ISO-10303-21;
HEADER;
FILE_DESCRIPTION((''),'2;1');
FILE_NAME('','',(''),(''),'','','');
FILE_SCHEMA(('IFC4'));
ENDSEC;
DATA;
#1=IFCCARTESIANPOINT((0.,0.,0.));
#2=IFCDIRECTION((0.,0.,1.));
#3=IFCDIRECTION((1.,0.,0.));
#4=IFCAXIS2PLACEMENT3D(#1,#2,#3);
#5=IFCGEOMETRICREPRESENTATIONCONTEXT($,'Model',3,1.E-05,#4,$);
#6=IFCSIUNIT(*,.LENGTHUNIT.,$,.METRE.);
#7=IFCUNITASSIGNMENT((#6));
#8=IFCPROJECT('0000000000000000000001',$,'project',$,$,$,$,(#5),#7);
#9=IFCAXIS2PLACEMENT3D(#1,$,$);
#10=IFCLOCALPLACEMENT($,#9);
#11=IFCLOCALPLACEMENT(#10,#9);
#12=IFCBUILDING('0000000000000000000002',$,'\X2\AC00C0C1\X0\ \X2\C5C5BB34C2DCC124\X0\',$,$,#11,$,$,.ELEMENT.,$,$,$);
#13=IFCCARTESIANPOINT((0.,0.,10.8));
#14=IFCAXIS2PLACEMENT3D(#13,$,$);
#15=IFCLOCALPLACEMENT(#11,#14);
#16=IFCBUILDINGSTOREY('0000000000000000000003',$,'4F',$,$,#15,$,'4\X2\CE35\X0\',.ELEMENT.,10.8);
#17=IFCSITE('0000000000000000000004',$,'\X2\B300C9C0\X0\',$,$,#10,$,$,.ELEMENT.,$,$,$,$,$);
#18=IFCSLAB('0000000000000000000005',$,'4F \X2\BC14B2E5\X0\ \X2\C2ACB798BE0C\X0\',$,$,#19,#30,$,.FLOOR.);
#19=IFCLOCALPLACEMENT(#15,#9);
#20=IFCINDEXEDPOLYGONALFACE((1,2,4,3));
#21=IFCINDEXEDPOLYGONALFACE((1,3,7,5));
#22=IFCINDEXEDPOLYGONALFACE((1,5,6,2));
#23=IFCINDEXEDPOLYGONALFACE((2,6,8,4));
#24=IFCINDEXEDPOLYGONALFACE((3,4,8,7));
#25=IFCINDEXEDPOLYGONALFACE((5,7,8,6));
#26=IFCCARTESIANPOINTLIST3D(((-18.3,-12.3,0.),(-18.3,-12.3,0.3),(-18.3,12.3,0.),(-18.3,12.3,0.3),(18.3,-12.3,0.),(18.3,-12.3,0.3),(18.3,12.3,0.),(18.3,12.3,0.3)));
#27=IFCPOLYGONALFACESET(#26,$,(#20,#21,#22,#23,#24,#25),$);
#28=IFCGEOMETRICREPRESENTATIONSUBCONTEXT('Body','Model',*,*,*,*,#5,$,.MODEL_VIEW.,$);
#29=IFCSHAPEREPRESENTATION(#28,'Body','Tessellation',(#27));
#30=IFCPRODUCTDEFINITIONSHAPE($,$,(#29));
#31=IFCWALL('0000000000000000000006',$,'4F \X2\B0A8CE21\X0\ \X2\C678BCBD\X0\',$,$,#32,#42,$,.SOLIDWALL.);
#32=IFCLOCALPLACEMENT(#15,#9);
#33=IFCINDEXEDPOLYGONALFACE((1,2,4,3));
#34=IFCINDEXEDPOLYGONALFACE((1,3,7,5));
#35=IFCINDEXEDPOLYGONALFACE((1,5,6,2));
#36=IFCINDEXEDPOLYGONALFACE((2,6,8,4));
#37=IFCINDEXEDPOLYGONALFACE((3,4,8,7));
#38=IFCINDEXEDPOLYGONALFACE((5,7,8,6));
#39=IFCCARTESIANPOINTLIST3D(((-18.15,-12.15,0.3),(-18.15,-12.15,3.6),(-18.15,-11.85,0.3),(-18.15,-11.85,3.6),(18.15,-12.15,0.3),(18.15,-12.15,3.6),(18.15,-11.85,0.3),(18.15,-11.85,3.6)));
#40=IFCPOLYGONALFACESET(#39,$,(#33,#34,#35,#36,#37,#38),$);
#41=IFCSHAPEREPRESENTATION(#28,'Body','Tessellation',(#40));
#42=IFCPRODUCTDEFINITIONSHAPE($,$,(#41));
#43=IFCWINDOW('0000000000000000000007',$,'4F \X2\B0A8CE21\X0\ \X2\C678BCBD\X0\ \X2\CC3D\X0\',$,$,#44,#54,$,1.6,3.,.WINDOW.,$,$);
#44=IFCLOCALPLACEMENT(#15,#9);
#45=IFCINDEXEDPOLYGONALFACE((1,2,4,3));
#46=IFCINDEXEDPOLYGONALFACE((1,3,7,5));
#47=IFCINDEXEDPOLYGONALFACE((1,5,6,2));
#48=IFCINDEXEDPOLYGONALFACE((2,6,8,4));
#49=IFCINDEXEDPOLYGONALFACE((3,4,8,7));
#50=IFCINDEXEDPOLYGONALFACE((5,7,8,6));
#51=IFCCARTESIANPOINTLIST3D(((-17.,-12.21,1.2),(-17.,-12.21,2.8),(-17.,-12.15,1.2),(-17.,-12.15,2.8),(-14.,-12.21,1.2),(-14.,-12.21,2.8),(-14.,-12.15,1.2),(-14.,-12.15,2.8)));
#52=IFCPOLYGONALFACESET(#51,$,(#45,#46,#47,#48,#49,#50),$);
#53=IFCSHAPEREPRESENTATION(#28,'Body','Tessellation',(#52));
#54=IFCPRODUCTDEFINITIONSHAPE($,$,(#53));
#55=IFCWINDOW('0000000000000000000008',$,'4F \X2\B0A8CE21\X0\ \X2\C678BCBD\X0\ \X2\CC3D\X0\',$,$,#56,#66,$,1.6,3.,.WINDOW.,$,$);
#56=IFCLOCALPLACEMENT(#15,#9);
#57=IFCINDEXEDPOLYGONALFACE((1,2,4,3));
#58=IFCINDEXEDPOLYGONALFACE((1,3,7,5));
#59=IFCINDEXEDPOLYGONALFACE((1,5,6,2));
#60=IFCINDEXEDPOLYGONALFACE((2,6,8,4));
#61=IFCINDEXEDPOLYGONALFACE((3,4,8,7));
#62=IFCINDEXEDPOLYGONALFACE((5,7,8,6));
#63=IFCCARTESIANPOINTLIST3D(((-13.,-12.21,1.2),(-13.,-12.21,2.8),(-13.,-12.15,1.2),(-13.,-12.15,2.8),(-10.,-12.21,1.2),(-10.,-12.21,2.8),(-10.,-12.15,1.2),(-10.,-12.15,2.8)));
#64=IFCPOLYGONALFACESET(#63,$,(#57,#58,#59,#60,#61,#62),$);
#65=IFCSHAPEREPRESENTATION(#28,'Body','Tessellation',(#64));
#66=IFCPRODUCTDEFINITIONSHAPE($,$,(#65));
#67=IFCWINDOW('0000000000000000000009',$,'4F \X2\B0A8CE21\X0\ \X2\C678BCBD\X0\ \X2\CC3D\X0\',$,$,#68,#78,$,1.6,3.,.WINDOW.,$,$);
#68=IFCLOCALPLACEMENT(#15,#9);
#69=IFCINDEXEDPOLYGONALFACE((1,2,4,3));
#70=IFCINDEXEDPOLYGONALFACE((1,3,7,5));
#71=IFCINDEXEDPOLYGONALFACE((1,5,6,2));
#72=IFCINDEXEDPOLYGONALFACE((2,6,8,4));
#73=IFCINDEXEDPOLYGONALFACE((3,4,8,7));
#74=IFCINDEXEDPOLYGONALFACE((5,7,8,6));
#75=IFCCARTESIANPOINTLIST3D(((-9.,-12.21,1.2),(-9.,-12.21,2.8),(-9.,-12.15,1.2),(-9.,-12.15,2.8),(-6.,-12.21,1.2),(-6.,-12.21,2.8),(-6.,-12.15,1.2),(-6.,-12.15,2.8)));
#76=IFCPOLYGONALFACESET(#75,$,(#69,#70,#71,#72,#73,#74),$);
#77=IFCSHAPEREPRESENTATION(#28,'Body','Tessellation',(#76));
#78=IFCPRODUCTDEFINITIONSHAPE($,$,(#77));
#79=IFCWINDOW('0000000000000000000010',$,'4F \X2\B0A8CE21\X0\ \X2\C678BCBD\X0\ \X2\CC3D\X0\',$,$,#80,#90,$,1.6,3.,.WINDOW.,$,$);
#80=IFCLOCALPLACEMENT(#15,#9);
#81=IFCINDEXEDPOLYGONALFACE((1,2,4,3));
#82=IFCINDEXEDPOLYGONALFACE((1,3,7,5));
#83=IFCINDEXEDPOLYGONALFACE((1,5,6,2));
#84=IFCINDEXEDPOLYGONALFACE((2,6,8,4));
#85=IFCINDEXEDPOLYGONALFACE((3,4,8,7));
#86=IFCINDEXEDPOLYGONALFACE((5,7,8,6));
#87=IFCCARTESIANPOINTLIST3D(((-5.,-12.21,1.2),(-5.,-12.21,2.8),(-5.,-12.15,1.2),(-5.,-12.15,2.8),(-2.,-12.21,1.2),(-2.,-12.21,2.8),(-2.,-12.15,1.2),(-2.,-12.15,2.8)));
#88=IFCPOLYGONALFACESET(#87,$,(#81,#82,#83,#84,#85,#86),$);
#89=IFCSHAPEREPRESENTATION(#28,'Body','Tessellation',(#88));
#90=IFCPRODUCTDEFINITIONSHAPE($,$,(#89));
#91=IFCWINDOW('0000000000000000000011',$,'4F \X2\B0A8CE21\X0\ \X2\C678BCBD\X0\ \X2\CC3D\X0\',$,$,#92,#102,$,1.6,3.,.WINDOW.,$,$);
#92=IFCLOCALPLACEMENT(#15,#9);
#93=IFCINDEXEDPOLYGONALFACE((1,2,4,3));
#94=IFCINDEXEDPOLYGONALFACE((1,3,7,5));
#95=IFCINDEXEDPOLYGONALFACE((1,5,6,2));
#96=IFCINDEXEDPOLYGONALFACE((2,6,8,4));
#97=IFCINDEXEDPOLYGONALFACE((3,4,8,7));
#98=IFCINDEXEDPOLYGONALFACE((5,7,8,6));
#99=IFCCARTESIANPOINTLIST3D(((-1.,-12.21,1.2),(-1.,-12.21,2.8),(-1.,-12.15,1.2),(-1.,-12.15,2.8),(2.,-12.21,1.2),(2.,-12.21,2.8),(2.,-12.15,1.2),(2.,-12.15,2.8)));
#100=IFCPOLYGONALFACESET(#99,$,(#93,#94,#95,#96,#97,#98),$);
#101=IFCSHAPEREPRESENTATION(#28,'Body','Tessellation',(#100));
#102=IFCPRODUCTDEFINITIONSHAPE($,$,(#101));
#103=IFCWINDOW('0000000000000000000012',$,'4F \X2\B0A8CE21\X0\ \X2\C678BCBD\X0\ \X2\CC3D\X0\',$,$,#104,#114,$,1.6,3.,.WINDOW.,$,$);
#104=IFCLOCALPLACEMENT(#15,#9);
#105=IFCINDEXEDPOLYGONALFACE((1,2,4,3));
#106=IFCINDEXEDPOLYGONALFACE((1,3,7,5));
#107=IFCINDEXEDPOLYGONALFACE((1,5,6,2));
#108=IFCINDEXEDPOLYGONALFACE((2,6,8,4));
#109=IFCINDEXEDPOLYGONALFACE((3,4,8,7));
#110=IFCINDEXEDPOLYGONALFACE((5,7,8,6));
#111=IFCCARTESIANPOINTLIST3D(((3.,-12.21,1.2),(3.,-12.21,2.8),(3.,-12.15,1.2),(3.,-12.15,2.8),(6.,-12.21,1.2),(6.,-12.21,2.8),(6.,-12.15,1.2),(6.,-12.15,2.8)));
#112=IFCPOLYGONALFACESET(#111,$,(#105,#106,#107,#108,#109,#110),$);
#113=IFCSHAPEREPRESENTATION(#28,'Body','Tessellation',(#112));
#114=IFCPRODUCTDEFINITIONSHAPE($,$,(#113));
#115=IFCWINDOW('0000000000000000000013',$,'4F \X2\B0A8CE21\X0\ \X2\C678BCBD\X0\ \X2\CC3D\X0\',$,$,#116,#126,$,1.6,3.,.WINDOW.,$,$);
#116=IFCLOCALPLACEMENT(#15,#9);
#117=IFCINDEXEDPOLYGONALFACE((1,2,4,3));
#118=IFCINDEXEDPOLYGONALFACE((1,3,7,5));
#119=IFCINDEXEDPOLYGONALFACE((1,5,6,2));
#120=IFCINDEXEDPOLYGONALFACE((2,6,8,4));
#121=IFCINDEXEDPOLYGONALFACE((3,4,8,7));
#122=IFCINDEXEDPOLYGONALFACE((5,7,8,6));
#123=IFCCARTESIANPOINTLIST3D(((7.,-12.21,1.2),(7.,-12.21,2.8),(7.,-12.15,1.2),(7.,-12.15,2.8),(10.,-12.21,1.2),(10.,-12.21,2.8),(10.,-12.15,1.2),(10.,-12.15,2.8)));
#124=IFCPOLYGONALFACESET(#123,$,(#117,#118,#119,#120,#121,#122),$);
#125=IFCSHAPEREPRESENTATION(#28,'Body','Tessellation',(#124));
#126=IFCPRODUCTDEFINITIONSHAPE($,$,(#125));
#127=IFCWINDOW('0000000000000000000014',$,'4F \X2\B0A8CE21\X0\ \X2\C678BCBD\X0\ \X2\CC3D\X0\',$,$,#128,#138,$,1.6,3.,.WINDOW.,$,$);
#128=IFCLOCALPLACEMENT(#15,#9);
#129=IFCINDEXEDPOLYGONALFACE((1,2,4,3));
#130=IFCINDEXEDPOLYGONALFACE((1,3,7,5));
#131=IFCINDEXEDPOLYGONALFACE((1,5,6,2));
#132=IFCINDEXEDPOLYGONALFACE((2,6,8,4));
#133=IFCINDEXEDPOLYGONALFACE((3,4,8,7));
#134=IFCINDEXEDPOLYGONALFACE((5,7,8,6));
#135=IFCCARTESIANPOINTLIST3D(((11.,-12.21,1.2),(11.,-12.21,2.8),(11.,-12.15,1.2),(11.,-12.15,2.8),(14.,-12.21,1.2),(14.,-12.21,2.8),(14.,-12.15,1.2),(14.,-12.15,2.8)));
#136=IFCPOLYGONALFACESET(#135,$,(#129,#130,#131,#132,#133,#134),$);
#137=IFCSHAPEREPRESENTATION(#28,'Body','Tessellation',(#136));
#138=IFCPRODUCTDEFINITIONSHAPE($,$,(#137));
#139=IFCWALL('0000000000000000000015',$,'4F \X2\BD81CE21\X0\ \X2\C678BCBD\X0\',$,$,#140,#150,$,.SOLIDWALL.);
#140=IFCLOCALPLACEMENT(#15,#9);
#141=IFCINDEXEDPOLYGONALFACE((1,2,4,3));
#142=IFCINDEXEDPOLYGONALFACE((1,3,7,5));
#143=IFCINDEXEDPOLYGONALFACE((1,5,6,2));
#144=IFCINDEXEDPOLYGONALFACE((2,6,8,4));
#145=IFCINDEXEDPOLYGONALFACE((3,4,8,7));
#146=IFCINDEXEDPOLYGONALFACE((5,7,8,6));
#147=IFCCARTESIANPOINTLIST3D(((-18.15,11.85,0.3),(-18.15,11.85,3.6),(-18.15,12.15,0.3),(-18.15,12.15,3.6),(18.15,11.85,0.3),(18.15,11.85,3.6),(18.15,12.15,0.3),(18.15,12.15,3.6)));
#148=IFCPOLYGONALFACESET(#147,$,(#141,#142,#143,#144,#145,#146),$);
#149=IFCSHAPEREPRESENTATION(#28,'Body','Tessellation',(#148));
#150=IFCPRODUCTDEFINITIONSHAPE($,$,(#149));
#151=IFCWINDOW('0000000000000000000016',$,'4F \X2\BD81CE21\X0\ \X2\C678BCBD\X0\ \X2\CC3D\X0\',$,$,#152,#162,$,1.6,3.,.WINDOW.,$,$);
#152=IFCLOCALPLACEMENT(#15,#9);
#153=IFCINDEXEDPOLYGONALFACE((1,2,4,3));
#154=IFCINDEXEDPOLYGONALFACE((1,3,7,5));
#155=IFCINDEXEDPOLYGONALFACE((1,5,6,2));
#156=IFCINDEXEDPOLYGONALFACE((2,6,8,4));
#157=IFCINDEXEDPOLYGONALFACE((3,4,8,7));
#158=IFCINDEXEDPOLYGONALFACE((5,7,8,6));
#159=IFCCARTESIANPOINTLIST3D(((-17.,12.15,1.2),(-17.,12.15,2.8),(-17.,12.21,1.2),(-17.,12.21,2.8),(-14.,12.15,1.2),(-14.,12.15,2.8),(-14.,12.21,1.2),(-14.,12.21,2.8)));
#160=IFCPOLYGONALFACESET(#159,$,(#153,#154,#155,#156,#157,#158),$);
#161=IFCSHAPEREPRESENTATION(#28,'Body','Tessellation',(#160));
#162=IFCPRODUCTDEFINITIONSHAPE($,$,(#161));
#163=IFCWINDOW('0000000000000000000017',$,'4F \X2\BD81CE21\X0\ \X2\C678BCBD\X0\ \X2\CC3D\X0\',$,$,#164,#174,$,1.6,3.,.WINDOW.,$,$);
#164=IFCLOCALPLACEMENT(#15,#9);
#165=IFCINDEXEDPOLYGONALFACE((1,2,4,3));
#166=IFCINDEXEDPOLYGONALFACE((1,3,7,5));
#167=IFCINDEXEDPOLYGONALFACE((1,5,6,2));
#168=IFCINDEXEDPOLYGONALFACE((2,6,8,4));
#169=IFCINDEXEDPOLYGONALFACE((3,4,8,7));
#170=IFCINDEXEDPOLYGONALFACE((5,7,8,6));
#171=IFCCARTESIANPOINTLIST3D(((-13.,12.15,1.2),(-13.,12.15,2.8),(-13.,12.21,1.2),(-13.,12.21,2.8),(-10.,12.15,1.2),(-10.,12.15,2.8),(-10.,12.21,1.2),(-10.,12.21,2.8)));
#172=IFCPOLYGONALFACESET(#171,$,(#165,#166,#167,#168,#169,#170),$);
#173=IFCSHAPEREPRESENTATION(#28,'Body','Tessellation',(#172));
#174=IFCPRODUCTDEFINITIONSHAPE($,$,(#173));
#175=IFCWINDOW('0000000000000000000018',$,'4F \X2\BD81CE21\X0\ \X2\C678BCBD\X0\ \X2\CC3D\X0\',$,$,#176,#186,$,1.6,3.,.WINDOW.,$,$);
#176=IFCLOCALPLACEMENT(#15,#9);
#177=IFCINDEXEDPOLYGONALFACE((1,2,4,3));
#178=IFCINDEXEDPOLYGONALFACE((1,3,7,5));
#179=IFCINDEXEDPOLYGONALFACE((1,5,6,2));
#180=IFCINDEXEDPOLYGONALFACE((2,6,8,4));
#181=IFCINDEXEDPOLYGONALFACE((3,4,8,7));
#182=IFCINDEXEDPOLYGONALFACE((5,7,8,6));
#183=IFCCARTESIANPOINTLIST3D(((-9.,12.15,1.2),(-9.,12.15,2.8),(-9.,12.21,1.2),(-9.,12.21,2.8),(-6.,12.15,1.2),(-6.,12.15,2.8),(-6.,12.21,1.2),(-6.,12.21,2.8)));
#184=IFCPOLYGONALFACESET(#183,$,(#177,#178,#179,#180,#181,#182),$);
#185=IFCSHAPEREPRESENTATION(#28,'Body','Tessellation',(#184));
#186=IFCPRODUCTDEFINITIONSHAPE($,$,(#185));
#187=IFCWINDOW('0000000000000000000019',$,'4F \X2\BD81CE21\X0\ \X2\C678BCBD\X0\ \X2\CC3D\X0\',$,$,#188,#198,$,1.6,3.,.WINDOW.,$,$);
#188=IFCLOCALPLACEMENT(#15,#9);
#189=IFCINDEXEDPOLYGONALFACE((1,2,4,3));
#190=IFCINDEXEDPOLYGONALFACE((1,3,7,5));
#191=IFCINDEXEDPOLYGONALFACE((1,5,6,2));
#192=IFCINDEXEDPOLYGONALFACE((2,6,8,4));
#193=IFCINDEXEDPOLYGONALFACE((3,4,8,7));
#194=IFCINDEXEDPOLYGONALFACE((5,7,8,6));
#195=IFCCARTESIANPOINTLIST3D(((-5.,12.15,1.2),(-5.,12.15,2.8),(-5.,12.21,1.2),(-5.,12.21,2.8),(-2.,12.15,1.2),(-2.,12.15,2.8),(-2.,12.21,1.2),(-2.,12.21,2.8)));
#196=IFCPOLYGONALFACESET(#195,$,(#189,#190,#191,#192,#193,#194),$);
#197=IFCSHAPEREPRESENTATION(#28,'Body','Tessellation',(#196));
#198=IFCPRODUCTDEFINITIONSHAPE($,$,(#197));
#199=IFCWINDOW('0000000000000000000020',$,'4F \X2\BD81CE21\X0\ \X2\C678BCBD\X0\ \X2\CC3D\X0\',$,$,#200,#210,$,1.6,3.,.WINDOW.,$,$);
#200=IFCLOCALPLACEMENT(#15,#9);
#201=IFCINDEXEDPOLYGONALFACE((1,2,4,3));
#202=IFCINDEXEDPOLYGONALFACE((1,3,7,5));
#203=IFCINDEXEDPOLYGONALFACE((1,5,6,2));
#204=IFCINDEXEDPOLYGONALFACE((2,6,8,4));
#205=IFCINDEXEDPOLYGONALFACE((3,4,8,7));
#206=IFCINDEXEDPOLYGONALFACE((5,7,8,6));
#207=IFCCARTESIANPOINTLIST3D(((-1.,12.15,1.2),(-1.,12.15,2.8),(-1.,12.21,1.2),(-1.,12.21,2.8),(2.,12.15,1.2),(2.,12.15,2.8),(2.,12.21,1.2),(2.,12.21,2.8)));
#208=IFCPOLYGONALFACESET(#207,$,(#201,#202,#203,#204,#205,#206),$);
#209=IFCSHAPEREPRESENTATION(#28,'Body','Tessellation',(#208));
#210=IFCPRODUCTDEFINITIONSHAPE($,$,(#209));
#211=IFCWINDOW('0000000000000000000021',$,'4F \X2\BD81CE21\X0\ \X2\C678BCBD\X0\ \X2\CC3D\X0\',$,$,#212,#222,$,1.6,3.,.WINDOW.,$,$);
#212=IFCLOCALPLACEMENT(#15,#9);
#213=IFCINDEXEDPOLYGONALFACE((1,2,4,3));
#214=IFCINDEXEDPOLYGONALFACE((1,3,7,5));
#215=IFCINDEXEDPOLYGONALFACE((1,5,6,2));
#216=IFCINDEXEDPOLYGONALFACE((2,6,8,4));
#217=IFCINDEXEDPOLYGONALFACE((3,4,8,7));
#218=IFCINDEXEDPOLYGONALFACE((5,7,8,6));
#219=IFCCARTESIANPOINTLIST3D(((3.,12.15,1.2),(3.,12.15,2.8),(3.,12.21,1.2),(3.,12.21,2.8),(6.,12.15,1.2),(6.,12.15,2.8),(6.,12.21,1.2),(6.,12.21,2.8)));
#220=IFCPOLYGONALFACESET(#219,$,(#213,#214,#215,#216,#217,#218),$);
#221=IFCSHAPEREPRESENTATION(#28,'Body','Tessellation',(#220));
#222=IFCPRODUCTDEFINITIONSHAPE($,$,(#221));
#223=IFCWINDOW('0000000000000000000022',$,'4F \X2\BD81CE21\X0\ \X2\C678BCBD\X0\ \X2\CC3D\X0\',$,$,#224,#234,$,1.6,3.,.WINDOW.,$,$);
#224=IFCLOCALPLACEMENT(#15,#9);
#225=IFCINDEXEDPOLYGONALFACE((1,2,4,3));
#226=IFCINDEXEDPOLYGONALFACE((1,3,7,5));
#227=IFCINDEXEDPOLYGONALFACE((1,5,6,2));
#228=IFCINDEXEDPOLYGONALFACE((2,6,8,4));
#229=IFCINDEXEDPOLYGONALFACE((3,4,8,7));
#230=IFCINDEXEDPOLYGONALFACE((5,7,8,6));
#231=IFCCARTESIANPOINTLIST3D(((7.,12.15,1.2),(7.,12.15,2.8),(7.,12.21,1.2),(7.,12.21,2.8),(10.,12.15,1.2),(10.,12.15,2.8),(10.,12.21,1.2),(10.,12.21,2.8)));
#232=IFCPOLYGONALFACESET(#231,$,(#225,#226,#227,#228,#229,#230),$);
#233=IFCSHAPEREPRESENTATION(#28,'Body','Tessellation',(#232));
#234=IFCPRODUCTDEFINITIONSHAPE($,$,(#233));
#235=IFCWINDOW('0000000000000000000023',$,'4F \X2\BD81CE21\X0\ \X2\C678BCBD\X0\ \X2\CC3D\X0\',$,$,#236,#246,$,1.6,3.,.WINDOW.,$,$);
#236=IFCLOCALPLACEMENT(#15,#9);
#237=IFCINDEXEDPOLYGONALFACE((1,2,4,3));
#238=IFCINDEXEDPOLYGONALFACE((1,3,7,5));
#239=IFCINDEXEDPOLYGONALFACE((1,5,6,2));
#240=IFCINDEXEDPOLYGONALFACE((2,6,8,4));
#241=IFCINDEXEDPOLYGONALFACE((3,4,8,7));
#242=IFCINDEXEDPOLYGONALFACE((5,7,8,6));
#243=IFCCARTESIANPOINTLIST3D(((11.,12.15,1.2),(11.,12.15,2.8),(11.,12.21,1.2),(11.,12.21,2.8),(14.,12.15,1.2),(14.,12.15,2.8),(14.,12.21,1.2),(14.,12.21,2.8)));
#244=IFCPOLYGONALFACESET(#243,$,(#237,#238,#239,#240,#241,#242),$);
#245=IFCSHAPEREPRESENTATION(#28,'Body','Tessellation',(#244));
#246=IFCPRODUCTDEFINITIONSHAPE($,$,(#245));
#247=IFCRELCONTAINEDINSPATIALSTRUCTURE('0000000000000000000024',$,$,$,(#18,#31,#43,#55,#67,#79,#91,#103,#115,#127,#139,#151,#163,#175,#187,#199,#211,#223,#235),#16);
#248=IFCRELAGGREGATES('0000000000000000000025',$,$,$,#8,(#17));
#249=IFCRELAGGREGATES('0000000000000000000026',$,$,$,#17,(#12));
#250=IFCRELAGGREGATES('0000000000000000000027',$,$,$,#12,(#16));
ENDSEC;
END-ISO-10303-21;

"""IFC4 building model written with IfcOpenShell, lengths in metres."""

from ifc_helpers import new_model, si_unit, frame, origin, origin_with_axes, origin_2d, place, context, subcontext, project, spatial, rectangle, extrude, element, save


model = new_model("IFC4")

# Units and contexts
model_context = context("Model", 3, precision=1e-05, world=origin_with_axes())
body_context = subcontext(model_context, "Body", "Model", "MODEL_VIEW")
ifc_project = project(units=[si_unit("LENGTHUNIT", "METRE")], contexts=[model_context])

# Site, building, storey
site_placement = place(None, origin())
site = spatial("IfcSite", under=ifc_project, at=site_placement, Name="대지", CompositionType="ELEMENT")
building_placement = place(site_placement, origin())
building = spatial("IfcBuilding", under=site, at=building_placement, Name="가상 업무시설", CompositionType="ELEMENT")
storey_placement = place(building_placement, frame((0.0, 0.0, 10.8)))
storey = spatial("IfcBuildingStorey", under=building, at=storey_placement, Name="4F", LongName="4층", CompositionType="ELEMENT", Elevation=10.8)

# Slab
slab_placement = place(storey_placement, origin())
element("IfcSlab", 1, at=slab_placement, inside=storey, Name="4F 바닥 슬래브", PredefinedType="FLOOR", context=body_context, shape_type="SweptSolid", body=[
    extrude(rectangle(XDim=36.6, YDim=24.6, at=origin_2d()), origin_with_axes(), (0.0, 0.0, 1.0), 0.3),
])

# Wall
wall_1_placement = place(storey_placement, frame((0.0, -12.0, 0.3)))
element("IfcWall", 2, at=wall_1_placement, inside=storey, Name="4F 남측 외벽", PredefinedType="SOLIDWALL", context=body_context, shape_type="SweptSolid", body=[
    extrude(rectangle(XDim=36.3, YDim=0.3, at=origin_2d()), origin_with_axes(), (0.0, 0.0, 1.0), 3.3),
])

# Windows
for number, where, name in (
    (3, (-15.5, -12.18, 1.2), "4F 남측 외벽 창"),
    (4, (-11.5, -12.18, 1.2), "4F 남측 외벽 창"),
    (5, (-7.5, -12.18, 1.2), "4F 남측 외벽 창"),
    (6, (-3.5, -12.18, 1.2), "4F 남측 외벽 창"),
    (7, (0.5, -12.18, 1.2), "4F 남측 외벽 창"),
    (8, (4.5, -12.18, 1.2), "4F 남측 외벽 창"),
    (9, (8.5, -12.18, 1.2), "4F 남측 외벽 창"),
    (10, (12.5, -12.18, 1.2), "4F 남측 외벽 창"),
):
    element("IfcWindow", number, at=place(storey_placement, frame(where)), inside=storey, Name=name, OverallHeight=1.6, OverallWidth=3.0, PredefinedType="WINDOW", context=body_context, shape_type="SweptSolid", body=[
        extrude(rectangle(XDim=3.0, YDim=0.06, at=origin_2d()), origin_with_axes(), (0.0, 0.0, 1.0), 1.6),
    ])

# Wall
wall_2_placement = place(storey_placement, frame((0.0, 12.0, 0.3)))
element("IfcWall", 11, at=wall_2_placement, inside=storey, Name="4F 북측 외벽", PredefinedType="SOLIDWALL", context=body_context, shape_type="SweptSolid", body=[
    extrude(rectangle(XDim=36.3, YDim=0.3, at=origin_2d()), origin_with_axes(), (0.0, 0.0, 1.0), 3.3),
])

# Windows
for number, where, name in (
    (12, (-15.5, 12.18, 1.2), "4F 북측 외벽 창"),
    (13, (-11.5, 12.18, 1.2), "4F 북측 외벽 창"),
    (14, (-7.5, 12.18, 1.2), "4F 북측 외벽 창"),
    (15, (-3.5, 12.18, 1.2), "4F 북측 외벽 창"),
    (16, (0.5, 12.18, 1.2), "4F 북측 외벽 창"),
    (17, (4.5, 12.18, 1.2), "4F 북측 외벽 창"),
    (18, (8.5, 12.18, 1.2), "4F 북측 외벽 창"),
    (19, (12.5, 12.18, 1.2), "4F 북측 외벽 창"),
):
    element("IfcWindow", number, at=place(storey_placement, frame(where)), inside=storey, Name=name, OverallHeight=1.6, OverallWidth=3.0, PredefinedType="WINDOW", context=body_context, shape_type="SweptSolid", body=[
        extrude(rectangle(XDim=3.0, YDim=0.06, at=origin_2d()), origin_with_axes(), (0.0, 0.0, 1.0), 1.6),
    ])

save(model, "model.ifc")
